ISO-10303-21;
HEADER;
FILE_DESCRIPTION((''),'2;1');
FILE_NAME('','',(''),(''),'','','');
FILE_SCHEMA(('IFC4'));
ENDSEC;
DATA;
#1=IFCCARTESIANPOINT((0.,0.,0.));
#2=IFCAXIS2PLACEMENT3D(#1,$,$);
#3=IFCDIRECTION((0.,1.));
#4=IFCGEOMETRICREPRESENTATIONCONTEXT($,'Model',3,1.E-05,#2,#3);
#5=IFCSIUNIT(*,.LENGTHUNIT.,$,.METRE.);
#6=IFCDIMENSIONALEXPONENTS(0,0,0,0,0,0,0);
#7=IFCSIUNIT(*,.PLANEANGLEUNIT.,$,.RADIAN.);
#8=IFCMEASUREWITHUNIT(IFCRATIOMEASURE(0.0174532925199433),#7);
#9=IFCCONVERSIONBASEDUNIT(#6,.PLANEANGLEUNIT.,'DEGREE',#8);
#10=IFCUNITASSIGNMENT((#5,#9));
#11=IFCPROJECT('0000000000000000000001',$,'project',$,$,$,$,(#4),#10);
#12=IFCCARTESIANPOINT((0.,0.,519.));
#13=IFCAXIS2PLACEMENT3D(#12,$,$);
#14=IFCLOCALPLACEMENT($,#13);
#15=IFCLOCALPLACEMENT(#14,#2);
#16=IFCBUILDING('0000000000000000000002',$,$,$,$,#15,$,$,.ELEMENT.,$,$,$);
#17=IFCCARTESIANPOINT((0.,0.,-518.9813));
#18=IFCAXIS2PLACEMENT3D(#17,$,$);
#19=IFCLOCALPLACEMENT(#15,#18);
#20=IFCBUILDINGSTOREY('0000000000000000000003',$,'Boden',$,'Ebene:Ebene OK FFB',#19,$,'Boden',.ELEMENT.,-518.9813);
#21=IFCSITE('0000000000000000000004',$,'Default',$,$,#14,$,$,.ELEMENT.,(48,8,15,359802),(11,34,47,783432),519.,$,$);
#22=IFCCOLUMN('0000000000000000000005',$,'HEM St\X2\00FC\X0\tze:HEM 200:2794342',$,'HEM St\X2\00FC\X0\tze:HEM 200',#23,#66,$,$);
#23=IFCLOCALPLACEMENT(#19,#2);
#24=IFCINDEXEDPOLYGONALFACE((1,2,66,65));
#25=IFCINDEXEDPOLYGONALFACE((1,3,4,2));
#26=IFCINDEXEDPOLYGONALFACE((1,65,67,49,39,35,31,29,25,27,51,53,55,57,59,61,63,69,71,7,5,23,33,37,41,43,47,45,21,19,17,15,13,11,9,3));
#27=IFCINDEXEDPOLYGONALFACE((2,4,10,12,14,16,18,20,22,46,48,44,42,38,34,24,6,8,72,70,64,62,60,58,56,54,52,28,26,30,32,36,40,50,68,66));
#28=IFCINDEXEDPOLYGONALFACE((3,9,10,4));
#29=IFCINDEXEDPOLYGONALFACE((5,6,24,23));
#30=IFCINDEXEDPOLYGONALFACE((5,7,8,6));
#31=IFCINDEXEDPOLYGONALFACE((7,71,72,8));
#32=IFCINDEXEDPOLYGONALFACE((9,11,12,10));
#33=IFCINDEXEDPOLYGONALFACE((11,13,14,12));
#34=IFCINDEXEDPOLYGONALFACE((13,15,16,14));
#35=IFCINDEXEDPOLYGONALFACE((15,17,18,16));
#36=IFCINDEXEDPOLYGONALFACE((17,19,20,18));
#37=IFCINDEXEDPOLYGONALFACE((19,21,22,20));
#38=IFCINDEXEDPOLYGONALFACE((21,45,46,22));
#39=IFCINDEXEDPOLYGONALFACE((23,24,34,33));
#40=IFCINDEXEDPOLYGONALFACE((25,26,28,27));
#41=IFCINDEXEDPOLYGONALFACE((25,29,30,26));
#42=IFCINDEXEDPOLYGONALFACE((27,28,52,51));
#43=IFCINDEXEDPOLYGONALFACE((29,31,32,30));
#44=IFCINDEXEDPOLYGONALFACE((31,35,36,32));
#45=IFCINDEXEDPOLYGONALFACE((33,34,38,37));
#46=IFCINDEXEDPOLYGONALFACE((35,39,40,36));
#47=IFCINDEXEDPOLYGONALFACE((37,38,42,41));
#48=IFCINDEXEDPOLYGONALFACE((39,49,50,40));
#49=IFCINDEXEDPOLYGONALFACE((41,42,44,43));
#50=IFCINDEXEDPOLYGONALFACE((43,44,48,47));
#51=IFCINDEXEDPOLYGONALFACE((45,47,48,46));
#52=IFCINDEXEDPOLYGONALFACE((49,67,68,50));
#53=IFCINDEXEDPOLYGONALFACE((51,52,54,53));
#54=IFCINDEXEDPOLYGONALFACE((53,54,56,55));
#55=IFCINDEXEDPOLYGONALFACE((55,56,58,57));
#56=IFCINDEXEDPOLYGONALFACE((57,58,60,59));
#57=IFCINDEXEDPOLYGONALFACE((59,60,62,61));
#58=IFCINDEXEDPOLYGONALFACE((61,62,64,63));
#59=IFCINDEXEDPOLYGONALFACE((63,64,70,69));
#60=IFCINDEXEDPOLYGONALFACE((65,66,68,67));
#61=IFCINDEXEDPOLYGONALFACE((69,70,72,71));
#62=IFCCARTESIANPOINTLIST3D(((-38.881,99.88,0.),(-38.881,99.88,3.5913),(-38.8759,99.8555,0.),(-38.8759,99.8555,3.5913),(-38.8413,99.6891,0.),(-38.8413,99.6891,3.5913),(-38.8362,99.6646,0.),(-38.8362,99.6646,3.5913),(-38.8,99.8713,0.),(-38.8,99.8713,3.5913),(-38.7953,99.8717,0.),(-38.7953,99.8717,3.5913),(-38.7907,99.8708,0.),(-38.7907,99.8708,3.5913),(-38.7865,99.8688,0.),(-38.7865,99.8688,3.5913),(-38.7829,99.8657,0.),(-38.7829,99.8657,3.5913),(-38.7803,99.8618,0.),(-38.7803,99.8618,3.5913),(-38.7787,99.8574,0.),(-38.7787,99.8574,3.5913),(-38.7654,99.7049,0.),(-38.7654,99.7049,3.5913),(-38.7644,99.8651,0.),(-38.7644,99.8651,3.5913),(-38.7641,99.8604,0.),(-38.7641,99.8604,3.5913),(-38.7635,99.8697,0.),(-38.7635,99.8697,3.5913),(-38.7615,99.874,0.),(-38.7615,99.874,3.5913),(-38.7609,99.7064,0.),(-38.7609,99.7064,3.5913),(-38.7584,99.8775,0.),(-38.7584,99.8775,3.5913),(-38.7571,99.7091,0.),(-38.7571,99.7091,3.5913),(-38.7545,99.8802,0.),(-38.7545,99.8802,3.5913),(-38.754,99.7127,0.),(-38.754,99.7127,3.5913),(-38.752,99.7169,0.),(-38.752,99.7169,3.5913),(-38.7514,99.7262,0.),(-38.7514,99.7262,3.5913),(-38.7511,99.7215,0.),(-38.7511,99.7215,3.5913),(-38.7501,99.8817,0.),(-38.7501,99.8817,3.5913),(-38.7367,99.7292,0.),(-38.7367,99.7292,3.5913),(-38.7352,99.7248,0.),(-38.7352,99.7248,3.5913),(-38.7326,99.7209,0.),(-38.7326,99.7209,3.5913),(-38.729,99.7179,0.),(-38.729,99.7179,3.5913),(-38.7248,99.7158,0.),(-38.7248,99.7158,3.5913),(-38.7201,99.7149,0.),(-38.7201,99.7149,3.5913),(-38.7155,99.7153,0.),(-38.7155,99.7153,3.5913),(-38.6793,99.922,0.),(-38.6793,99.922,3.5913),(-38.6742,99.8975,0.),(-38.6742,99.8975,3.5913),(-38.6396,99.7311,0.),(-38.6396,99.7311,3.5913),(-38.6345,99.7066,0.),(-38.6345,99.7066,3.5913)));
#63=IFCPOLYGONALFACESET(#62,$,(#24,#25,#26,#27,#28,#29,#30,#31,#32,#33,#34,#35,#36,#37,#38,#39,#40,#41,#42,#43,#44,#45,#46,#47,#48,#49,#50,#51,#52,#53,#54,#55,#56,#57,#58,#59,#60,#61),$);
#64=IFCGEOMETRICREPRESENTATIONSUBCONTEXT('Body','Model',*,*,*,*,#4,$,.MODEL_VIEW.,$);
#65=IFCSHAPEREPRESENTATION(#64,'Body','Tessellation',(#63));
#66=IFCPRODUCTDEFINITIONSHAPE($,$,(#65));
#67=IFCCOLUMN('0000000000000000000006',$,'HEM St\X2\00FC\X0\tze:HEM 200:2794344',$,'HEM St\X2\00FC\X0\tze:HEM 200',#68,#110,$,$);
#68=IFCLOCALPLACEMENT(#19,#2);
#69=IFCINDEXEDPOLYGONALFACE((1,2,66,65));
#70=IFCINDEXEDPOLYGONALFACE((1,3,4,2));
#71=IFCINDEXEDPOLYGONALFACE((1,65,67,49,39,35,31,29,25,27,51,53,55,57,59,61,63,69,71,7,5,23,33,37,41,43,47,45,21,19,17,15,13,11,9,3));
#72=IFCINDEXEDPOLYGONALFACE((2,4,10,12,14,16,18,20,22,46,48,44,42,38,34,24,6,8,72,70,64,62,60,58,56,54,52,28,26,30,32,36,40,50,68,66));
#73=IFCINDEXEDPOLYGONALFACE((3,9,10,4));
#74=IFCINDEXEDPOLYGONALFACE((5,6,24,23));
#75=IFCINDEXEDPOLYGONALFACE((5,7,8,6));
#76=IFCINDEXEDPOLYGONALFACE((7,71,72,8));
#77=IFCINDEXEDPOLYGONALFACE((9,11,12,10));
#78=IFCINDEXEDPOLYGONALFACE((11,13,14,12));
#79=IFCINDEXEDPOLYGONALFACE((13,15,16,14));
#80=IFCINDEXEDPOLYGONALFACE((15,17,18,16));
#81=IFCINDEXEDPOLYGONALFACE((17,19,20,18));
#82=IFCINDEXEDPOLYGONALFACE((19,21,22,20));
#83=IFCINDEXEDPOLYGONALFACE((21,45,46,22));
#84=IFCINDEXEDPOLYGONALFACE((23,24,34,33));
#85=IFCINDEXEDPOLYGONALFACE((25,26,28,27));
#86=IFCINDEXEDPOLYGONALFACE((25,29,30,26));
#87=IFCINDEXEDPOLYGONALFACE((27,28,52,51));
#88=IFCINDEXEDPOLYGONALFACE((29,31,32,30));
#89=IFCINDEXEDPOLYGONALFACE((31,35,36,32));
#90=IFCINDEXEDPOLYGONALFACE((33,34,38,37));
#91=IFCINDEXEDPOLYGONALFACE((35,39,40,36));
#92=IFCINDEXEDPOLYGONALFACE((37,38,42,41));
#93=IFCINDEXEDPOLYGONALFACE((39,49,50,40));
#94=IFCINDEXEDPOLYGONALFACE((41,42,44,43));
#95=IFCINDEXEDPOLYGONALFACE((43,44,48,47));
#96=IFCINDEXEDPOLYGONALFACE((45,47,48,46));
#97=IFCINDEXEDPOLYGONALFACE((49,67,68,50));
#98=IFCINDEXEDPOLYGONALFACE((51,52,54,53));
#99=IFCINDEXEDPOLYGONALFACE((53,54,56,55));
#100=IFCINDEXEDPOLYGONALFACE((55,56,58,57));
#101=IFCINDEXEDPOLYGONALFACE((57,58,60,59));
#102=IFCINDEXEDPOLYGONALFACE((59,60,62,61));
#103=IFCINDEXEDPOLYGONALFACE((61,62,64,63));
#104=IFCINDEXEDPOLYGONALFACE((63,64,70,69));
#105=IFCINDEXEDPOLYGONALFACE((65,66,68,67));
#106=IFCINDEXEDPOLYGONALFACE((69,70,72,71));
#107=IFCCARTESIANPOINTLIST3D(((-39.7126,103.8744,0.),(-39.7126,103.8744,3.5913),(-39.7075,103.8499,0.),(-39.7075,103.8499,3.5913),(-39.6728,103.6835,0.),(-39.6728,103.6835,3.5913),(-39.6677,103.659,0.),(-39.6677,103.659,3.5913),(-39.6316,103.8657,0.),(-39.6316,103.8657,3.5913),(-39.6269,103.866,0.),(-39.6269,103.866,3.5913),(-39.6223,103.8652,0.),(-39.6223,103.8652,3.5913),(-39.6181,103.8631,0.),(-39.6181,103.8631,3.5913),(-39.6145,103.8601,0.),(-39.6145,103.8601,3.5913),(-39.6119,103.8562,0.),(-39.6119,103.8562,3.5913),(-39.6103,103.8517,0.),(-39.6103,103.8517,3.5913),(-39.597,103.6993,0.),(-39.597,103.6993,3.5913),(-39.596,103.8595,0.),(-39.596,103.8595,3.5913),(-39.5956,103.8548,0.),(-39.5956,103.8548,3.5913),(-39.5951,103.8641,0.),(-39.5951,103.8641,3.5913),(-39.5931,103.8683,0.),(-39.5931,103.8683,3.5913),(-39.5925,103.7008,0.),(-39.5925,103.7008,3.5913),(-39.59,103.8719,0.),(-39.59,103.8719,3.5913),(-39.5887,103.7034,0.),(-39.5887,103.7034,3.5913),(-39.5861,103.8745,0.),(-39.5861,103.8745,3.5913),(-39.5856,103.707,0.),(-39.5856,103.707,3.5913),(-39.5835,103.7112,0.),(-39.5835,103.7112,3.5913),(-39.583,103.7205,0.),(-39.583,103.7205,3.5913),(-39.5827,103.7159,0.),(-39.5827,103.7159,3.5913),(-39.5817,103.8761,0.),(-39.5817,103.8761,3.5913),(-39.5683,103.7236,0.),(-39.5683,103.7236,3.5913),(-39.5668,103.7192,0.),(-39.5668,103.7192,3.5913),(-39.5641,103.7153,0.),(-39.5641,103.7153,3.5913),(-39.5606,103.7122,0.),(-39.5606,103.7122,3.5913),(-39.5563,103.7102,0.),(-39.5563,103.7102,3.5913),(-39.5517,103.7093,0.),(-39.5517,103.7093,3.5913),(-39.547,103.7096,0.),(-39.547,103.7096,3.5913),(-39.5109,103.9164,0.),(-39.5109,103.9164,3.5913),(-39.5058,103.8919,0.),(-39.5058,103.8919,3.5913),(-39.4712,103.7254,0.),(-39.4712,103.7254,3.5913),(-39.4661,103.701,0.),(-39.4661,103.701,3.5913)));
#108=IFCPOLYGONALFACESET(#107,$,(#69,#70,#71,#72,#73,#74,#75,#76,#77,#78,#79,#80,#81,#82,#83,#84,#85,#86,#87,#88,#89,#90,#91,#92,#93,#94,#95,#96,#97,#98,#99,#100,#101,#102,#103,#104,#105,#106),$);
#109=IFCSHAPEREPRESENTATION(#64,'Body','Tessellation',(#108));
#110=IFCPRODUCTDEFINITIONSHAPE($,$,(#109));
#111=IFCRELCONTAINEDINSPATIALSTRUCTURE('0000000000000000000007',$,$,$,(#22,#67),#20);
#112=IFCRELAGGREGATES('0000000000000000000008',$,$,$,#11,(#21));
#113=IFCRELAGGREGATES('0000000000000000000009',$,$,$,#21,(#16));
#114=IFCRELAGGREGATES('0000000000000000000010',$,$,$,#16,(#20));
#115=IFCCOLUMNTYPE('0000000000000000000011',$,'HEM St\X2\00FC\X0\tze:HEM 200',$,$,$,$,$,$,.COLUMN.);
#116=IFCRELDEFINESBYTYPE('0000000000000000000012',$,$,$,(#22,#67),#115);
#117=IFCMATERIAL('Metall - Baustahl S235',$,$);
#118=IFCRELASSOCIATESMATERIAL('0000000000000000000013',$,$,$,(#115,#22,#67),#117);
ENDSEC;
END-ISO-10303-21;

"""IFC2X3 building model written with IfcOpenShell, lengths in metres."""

from ifc_helpers import new_model, entity, si_unit, converted_unit, direction, frame, frame_2d, origin, place, context, subcontext, project, spatial, polyline, circle_curve, parameter, trimmed, segment, composite_curve, outline, extrude, source, transform, mapped, material, type_object, type_shapes, element, save


model = new_model("IFC2X3")

# Units and contexts
model_context = context("Model", 3, precision=1e-05, world=origin(), true_north=direction((0.0, 1.0)))
body_context = subcontext(model_context, "Body", "Model", "MODEL_VIEW")
ifc_project = project(units=[si_unit("LENGTHUNIT", "METRE"), converted_unit("PLANEANGLEUNIT", "DEGREE", entity("IfcRatioMeasure", 0.0174532925199433), si_unit("PLANEANGLEUNIT", "RADIAN"), dimensions=[0, 0, 0, 0, 0, 0, 0])], contexts=[model_context])

# Site, building, storey
site_placement = place(None, frame((0.0, 0.0, 519.0)))
site = spatial("IfcSite", under=ifc_project, at=site_placement, Name="Default", CompositionType="ELEMENT", RefLatitude=(48, 8, 15, 359802), RefLongitude=(11, 34, 47, 783432), RefElevation=519.0)
building_placement = place(site_placement, origin())
building = spatial("IfcBuilding", under=site, at=building_placement, CompositionType="ELEMENT")
storey_placement = place(building_placement, frame((0.0, 0.0, -518.9813)))
storey = spatial("IfcBuildingStorey", under=building, at=storey_placement, Name="Boden", ObjectType="Ebene:Ebene OK FFB", LongName="Boden", CompositionType="ELEMENT", Elevation=-518.9813)

# Columns
ifc_material = material(Name="Metall - Baustahl S235")
column_type = type_object("IfcColumnType", Name="HEM Stütze:HEM 200", PredefinedType="COLUMN", material=ifc_material)
shared_shape = source(origin(), body_context, "Body", "SweptSolid", [
    extrude(outline(composite_curve([segment(polyline([(0.085, -0.103), (0.11, -0.103)]), True, "CONTINUOUS"), segment(polyline([(0.11, -0.103), (0.11, 0.103)]), True, "CONTINUOUS"), segment(polyline([(0.11, 0.103), (0.085, 0.103)]), True, "CONTINUOUS"), segment(polyline([(0.085, 0.103), (0.085, 0.0255)]), True, "CONTINUOUS"), segment(trimmed(circle_curve(frame_2d((0.067, 0.0255), x_axis=(1.0, 0.0)), 0.018), [parameter(270.0)], [parameter(0.0)], True, "PARAMETER"), False, "CONTINUOUS"), segment(polyline([(0.067, 0.0075), (-0.067, 0.0075)]), True, "CONTINUOUS"), segment(trimmed(circle_curve(frame_2d((-0.067, 0.0255), x_axis=(0.0, -1.0)), 0.018), [parameter(270.0)], [parameter(0.0)], True, "PARAMETER"), False, "CONTINUOUS"), segment(polyline([(-0.085, 0.0255), (-0.085, 0.103)]), True, "CONTINUOUS"), segment(polyline([(-0.085, 0.103), (-0.11, 0.103)]), True, "CONTINUOUS"), segment(polyline([(-0.11, 0.103), (-0.11, -0.103)]), True, "CONTINUOUS"), segment(polyline([(-0.11, -0.103), (-0.085, -0.103)]), True, "CONTINUOUS"), segment(polyline([(-0.085, -0.103), (-0.085, -0.0255)]), True, "CONTINUOUS"), segment(trimmed(circle_curve(frame_2d((-0.067, -0.0255), x_axis=(-1.0, 0.0)), 0.018), [parameter(270.0)], [parameter(0.0)], True, "PARAMETER"), False, "CONTINUOUS"), segment(polyline([(-0.067, -0.0075), (0.067, -0.0075)]), True, "CONTINUOUS"), segment(trimmed(circle_curve(frame_2d((0.067, -0.0255), x_axis=(0.0, 1.0)), 0.018), [parameter(270.0)], [parameter(0.0)], True, "PARAMETER"), False, "CONTINUOUS"), segment(polyline([(0.085, -0.0255), (0.085, -0.103)]), True, "CONTINUOUS")], self_intersect=False)), frame((0.0, 0.0, -518.9813), z_axis=(0.0, 0.0, 1.0), x_axis=(0.0, -1.0, 0.0)), (0.0, 0.0, 1.0), 3.5913),
])
type_shapes(column_type, [shared_shape])
for number, where, z_axis, x_axis, name in (
    (1, (-38.7577, 99.7933, 518.9813), (0.0, 0.0, 1.0), (0.979008, 0.20382, 0.0), "HEM Stütze:HEM 200:2794342"),
    (2, (-39.5893, 103.7877, 518.9813), (0.0, 0.0, 1.0), (0.979008, 0.20382, 0.0), "HEM Stütze:HEM 200:2794344"),
):
    element("IfcColumn", number, at=place(storey_placement, frame(where, z_axis=z_axis, x_axis=x_axis)), inside=storey, type_object=column_type, material=ifc_material, Name=name, ObjectType="HEM Stütze:HEM 200", context=body_context, shape_type="MappedRepresentation", body=[
        mapped(shared_shape, transform((0.0, 0.0, 0.0), scale=1.0)),
    ])

save(model, "model.ifc")
